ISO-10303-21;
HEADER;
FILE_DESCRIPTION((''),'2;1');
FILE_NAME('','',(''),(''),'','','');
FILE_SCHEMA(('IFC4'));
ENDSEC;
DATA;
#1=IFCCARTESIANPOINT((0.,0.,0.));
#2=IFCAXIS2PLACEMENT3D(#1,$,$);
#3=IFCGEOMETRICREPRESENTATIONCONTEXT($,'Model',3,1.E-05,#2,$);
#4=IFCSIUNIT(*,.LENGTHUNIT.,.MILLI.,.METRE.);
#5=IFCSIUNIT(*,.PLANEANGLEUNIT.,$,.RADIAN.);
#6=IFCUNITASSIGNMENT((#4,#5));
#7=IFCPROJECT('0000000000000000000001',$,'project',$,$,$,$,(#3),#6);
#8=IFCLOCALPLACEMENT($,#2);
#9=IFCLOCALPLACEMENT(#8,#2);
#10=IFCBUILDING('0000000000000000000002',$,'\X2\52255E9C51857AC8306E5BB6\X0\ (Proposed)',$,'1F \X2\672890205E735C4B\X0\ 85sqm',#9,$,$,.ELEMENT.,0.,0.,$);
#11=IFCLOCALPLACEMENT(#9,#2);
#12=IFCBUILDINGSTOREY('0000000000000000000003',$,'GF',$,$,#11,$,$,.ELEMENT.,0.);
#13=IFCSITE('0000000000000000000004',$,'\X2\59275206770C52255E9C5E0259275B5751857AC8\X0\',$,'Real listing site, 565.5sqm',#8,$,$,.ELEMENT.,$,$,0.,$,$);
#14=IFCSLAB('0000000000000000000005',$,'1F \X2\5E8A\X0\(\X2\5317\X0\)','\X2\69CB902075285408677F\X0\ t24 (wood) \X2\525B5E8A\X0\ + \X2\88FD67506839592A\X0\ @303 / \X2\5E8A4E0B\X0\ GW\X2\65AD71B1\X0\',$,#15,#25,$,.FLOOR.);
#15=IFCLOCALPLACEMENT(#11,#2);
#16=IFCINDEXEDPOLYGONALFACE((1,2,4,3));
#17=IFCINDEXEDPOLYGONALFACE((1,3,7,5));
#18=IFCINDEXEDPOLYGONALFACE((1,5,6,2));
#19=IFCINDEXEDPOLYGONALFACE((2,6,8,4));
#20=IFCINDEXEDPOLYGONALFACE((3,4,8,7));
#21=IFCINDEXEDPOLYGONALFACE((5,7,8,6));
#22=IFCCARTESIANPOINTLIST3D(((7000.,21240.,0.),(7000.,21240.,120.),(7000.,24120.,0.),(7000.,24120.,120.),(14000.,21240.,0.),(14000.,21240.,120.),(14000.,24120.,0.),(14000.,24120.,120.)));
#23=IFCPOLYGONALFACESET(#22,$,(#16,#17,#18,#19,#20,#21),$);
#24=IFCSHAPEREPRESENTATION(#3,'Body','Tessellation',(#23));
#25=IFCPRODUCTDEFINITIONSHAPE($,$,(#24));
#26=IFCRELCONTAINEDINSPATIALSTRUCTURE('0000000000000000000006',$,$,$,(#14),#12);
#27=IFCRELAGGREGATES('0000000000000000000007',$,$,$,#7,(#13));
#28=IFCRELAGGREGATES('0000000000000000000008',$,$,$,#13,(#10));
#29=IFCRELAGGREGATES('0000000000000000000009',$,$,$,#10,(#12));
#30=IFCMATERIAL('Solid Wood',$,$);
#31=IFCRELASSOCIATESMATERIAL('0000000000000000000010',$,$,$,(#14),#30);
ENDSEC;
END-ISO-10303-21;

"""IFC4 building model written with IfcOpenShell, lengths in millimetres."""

from ifc_helpers import new_model, si_unit, frame, frame_2d, origin, place, context, project, spatial, rectangle, extrude, material, element, save


model = new_model("IFC4")

# Units and contexts
model_context = context("Model", 3, precision=1e-05, world=origin())
ifc_project = project(units=[si_unit("LENGTHUNIT", "METRE", prefix="MILLI"), si_unit("PLANEANGLEUNIT", "RADIAN")], contexts=[model_context])

# Site, building, storey
site_placement = place(None, origin())
site = spatial("IfcSite", under=ifc_project, at=site_placement, Name="大分県別府市大字内竈", ObjectType="Real listing site, 565.5sqm", CompositionType="ELEMENT", RefElevation=0.0)
building_placement = place(site_placement, origin())
building = spatial("IfcBuilding", under=site, at=building_placement, Name="別府内竈の家 (Proposed)", ObjectType="1F 木造平屋 85sqm", CompositionType="ELEMENT", ElevationOfRefHeight=0.0, ElevationOfTerrain=0.0)
storey_placement = place(building_placement, origin())
storey = spatial("IfcBuildingStorey", under=building, at=storey_placement, Name="GF", CompositionType="ELEMENT", Elevation=0.0)

# Slab
ifc_material_1 = material(Name="Solid Wood")
slab_1_placement = place(storey_placement, frame((3500.0, 10620.0, 0.0)))
element("IfcSlab", 1, at=slab_1_placement, inside=storey, material=ifc_material_1, Name="1F 床(北)", Description="構造用合板 t24 (wood) 剛床 + 製材根太 @303 / 床下 GW断熱", PredefinedType="FLOOR", context=model_context, shape_type="SweptSolid", body=[
    extrude(rectangle(XDim=7000.0, YDim=2880.0, at=frame_2d((3500.0, 1440.0))), frame((3500.0, 10620.0, 0.0)), (0.0, 0.0, 1.0), 120.0),
])

save(model, "model.ifc")
